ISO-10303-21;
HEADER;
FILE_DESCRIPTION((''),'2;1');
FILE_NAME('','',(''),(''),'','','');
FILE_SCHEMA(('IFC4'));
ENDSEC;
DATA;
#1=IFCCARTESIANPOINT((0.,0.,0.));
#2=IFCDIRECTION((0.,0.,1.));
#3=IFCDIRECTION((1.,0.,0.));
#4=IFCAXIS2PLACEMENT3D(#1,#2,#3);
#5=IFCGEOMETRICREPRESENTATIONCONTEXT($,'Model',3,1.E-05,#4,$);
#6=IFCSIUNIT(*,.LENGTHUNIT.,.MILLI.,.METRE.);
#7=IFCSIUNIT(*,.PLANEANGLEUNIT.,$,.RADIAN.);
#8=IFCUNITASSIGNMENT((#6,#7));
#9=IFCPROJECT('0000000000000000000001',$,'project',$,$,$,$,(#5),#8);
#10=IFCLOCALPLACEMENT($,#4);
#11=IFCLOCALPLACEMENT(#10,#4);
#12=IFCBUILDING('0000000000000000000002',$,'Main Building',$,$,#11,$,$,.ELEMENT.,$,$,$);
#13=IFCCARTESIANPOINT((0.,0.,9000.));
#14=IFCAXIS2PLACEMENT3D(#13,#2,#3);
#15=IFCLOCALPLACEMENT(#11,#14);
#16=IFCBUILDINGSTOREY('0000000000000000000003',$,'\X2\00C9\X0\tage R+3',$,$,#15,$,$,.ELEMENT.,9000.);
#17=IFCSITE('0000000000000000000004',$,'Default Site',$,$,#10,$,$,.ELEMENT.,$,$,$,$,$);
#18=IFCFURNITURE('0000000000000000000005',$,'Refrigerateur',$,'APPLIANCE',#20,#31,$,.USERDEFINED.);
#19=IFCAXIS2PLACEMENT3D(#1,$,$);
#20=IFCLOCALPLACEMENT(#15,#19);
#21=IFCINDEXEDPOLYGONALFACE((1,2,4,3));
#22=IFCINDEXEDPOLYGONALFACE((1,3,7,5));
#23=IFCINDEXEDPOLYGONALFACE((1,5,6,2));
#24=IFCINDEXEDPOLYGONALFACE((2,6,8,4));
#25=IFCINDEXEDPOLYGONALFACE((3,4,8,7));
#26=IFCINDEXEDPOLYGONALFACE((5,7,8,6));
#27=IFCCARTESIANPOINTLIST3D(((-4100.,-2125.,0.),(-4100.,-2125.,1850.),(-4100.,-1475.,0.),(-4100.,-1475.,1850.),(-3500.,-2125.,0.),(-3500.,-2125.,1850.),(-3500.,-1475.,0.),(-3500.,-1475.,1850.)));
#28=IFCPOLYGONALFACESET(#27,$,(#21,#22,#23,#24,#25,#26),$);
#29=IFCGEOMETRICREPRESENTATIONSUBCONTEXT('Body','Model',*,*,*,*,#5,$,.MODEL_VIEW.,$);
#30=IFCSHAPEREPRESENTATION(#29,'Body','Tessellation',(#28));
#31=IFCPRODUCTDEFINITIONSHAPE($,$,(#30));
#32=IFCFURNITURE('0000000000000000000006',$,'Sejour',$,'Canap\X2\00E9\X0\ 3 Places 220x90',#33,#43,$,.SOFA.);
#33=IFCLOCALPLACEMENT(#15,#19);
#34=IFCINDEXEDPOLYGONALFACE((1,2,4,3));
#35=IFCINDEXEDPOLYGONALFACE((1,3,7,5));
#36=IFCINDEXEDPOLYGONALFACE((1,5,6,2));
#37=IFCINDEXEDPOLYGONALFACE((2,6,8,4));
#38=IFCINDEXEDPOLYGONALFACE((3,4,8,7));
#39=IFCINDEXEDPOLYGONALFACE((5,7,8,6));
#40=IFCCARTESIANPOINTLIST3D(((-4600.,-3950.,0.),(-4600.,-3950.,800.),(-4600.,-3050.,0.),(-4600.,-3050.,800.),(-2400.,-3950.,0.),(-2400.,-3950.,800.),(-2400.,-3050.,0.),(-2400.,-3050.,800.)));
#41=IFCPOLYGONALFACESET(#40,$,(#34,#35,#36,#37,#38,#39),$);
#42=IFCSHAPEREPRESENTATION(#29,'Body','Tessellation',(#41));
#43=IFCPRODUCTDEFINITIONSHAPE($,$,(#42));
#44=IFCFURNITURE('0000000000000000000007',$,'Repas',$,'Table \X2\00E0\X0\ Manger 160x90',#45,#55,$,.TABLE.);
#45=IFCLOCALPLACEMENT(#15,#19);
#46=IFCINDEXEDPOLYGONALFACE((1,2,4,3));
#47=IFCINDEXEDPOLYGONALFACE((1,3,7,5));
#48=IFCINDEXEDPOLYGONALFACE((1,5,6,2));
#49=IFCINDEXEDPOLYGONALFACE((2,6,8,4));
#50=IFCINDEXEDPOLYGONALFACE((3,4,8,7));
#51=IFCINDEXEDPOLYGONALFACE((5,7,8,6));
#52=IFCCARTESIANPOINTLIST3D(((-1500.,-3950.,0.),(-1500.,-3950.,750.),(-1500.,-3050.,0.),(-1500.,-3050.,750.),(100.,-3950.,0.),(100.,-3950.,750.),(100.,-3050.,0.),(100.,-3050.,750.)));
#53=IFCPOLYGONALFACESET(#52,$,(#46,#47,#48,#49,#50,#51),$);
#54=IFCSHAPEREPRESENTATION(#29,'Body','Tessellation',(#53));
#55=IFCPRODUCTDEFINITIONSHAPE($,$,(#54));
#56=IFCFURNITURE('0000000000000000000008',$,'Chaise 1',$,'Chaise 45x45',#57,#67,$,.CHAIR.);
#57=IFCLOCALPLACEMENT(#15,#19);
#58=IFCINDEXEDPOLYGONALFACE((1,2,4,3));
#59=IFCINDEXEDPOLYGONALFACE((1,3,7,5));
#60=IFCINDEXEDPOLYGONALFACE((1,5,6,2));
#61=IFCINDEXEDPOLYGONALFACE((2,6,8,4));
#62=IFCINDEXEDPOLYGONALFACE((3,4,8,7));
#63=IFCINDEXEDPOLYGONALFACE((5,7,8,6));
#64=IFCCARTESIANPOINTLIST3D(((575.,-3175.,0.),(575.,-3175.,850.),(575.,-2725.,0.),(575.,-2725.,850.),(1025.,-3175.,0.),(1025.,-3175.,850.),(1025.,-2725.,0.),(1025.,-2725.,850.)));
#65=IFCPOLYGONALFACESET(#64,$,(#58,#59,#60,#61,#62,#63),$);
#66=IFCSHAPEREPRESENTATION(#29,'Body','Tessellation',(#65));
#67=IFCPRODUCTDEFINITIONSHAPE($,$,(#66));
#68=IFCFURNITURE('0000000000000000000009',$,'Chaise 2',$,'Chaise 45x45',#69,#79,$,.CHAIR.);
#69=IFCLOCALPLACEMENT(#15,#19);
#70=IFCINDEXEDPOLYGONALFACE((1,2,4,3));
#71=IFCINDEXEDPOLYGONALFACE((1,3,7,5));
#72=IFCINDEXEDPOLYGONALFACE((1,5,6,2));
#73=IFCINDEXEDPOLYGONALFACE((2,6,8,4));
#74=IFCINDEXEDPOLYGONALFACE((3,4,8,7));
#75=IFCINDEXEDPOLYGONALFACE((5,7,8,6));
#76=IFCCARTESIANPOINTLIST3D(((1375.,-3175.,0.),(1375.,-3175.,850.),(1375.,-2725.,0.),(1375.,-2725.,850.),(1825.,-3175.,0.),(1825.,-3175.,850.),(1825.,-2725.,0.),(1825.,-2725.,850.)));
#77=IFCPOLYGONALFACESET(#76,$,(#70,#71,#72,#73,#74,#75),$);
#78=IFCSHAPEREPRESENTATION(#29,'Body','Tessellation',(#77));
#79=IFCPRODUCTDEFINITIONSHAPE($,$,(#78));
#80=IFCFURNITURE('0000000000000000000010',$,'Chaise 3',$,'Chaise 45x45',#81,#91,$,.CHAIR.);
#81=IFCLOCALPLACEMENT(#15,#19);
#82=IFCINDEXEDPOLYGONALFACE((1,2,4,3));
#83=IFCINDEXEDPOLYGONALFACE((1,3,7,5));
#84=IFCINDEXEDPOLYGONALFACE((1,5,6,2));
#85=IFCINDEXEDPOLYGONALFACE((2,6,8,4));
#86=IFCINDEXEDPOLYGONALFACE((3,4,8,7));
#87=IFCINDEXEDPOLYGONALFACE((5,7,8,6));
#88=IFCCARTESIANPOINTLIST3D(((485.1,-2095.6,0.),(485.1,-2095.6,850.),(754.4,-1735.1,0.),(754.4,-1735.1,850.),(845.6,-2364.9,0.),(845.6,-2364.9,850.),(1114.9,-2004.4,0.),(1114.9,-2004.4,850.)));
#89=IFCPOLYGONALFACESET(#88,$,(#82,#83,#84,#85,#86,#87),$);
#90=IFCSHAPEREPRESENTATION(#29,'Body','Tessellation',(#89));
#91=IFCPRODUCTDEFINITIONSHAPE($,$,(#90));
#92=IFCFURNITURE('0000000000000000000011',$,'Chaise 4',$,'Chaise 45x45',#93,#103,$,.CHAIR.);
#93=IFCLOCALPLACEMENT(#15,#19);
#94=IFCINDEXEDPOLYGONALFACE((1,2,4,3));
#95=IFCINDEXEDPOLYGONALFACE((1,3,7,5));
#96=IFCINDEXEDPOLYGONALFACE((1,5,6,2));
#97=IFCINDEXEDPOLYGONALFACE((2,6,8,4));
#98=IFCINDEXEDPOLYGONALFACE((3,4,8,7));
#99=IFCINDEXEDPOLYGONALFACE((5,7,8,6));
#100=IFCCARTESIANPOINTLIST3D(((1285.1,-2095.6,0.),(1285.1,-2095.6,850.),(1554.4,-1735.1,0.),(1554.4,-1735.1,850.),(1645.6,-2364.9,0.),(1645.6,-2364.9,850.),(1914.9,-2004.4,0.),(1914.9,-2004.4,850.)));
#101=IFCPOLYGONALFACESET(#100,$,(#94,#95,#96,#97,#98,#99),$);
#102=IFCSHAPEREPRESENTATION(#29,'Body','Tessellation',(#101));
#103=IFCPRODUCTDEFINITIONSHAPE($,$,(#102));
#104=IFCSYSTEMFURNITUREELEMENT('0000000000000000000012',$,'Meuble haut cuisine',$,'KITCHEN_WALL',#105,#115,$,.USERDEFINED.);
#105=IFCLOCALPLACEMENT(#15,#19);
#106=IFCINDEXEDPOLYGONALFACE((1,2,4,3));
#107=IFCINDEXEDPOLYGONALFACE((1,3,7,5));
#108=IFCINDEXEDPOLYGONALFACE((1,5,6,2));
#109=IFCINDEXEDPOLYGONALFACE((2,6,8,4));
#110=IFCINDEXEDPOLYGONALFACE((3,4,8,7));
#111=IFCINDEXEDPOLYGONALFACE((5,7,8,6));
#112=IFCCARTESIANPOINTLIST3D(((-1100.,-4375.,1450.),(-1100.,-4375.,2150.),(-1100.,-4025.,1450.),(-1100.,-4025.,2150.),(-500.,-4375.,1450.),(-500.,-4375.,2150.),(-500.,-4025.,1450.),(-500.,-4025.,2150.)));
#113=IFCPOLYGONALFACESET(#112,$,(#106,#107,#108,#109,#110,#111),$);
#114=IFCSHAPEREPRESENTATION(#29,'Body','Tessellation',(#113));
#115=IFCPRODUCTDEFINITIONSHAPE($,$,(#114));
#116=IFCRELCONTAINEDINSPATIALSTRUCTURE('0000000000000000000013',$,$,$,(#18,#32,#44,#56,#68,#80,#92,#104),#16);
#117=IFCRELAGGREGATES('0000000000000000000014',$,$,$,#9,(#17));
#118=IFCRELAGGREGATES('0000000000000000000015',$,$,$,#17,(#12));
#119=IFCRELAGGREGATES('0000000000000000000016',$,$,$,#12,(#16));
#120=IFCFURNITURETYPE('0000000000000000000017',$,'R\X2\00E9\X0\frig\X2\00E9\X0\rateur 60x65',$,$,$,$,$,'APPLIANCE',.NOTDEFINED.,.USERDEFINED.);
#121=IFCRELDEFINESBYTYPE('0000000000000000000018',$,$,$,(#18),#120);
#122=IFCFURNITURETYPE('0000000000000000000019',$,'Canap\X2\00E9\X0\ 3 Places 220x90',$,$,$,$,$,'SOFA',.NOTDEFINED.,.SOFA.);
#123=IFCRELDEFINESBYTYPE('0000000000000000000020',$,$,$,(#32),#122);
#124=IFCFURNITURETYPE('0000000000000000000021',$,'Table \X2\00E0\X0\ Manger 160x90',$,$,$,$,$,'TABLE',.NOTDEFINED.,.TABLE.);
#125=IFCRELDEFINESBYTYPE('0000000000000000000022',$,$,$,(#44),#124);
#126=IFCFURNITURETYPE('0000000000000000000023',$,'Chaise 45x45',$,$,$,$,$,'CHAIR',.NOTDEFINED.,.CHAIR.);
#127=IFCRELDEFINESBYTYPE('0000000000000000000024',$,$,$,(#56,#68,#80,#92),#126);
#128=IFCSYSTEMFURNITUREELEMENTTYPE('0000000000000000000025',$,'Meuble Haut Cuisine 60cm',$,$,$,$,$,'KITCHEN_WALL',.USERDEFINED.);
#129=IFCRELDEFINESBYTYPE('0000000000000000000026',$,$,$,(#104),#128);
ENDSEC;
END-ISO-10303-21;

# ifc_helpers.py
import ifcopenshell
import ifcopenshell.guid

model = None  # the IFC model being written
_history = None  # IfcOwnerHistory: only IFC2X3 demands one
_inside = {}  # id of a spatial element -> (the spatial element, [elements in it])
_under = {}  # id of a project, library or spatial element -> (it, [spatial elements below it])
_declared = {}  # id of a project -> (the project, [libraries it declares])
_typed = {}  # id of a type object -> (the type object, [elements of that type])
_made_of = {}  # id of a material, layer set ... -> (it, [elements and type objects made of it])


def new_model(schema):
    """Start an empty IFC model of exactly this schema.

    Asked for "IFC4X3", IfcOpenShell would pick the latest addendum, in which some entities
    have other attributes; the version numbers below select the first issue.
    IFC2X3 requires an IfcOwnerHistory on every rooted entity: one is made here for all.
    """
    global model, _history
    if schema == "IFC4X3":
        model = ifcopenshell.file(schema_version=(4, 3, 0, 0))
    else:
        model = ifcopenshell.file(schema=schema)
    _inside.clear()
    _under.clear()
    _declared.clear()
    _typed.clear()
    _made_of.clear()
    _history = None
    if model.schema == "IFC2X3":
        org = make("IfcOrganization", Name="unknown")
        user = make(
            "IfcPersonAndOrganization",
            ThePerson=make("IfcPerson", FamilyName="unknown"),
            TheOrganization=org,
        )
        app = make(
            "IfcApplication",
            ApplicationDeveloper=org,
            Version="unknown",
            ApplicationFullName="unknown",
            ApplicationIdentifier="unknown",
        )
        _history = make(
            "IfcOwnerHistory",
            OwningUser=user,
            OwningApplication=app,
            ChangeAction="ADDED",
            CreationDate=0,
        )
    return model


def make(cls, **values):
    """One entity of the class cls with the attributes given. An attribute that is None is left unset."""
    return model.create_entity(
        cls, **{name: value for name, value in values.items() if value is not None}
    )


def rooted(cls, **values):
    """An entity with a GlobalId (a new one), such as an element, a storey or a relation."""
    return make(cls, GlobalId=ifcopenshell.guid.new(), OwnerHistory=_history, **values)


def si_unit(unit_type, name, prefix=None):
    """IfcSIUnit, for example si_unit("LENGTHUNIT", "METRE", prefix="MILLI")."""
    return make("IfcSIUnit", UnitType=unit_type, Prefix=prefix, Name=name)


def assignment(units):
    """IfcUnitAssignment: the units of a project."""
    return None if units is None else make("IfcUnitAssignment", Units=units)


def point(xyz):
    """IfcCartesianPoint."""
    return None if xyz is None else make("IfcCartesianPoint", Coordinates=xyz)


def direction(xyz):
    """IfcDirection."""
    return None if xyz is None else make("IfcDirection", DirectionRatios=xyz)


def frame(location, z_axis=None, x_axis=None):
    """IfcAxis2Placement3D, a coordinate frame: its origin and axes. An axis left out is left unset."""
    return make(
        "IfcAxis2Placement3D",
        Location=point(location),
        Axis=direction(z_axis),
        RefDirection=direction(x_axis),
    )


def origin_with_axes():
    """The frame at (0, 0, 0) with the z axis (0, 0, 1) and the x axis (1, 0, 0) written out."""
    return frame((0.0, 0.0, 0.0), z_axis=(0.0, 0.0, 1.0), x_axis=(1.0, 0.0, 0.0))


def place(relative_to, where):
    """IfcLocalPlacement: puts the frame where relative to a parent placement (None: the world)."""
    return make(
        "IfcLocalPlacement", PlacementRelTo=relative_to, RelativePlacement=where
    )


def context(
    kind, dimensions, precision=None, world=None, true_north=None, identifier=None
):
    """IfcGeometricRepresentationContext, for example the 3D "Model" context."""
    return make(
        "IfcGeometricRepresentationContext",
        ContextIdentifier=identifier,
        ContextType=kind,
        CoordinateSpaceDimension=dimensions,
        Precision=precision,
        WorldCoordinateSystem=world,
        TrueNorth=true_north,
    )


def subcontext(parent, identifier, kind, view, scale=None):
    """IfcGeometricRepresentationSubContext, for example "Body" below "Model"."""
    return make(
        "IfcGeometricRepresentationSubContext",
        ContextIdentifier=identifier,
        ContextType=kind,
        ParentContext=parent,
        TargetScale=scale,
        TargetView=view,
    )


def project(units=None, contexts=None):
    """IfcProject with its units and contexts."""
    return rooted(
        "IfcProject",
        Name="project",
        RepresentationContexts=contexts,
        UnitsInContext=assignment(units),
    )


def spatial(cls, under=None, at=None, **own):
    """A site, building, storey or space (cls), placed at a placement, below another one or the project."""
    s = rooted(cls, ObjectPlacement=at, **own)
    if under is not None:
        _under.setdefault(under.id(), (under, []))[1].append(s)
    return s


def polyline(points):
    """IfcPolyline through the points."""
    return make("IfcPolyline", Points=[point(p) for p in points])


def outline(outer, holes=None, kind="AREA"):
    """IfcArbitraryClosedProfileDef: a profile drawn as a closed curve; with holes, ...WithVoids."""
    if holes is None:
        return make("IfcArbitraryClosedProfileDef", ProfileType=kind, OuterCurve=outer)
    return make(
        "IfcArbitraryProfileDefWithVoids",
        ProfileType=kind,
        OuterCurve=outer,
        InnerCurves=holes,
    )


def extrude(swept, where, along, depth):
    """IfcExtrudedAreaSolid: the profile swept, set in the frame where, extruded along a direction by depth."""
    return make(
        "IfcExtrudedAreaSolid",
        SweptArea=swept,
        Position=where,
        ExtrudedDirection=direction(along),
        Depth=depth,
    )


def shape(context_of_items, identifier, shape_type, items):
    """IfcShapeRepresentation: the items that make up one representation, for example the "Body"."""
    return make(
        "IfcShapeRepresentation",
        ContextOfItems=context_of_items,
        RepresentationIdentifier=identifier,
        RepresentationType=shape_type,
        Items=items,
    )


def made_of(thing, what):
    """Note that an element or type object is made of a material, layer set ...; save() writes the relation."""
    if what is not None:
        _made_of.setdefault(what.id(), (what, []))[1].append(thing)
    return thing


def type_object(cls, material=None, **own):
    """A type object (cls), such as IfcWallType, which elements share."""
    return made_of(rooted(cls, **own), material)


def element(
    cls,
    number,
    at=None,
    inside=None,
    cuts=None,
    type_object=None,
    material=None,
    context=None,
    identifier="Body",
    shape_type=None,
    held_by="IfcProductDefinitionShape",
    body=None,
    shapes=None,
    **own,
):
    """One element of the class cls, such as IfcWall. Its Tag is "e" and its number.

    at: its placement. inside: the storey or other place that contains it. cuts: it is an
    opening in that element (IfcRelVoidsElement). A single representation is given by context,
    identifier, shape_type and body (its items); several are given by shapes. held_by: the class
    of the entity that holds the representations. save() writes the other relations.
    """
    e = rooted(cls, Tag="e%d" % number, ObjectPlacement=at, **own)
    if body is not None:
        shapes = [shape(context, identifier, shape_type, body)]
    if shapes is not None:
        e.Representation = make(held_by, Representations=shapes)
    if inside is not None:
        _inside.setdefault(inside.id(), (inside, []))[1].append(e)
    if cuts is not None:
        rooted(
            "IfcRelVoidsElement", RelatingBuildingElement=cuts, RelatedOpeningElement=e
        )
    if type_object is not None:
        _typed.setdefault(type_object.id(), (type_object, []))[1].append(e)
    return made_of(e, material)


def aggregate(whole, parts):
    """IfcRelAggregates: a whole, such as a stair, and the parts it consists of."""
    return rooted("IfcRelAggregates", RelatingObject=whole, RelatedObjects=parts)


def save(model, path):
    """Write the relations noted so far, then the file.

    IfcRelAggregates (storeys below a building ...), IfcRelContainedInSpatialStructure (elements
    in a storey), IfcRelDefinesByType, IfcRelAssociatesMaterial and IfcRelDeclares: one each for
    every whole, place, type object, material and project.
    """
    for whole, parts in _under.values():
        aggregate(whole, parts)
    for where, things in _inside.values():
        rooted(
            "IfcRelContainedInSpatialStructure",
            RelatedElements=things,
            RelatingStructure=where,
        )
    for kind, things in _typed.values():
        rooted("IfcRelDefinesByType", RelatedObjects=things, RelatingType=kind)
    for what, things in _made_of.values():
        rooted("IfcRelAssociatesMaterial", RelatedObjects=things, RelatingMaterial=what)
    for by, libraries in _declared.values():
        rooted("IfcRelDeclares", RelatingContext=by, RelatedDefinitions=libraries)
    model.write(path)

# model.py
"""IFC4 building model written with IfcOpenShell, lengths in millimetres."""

from ifc_helpers import new_model, si_unit, frame, origin_with_axes, place, context, subcontext, project, spatial, polyline, outline, extrude, type_object, element, save


model = new_model("IFC4")

# Units and contexts
model_context = context("Model", 3, precision=1e-05, world=origin_with_axes())
body_context = subcontext(model_context, "Body", "Model", "MODEL_VIEW")
ifc_project = project(units=[si_unit("LENGTHUNIT", "METRE", prefix="MILLI"), si_unit("PLANEANGLEUNIT", "RADIAN")], contexts=[model_context])

# Site, building, storey
site_placement = place(None, origin_with_axes())
site = spatial("IfcSite", under=ifc_project, at=site_placement, Name="Default Site", CompositionType="ELEMENT")
building_placement = place(site_placement, origin_with_axes())
building = spatial("IfcBuilding", under=site, at=building_placement, Name="Main Building", CompositionType="ELEMENT")
storey_placement = place(building_placement, frame((0.0, 0.0, 9000.0), z_axis=(0.0, 0.0, 1.0), x_axis=(1.0, 0.0, 0.0)))
storey = spatial("IfcBuildingStorey", under=building, at=storey_placement, Name="Étage R+3", CompositionType="ELEMENT", Elevation=9000.0)

# Furniture
furniture_type_1 = type_object("IfcFurnitureType", Name="Réfrigérateur 60x65", ElementType="APPLIANCE", AssemblyPlace="NOTDEFINED", PredefinedType="USERDEFINED")
furniture_1_placement = place(storey_placement, frame((-3800.0, -1800.0, 0.0), z_axis=(0.0, 0.0, 1.0), x_axis=(1.0, 0.0, 0.0)))
element("IfcFurniture", 1, at=furniture_1_placement, inside=storey, type_object=furniture_type_1, Name="Refrigerateur", ObjectType="APPLIANCE", PredefinedType="USERDEFINED", context=body_context, shape_type="SweptSolid", body=[
    extrude(outline(polyline([(-300.0, -325.0), (300.0, -325.0), (300.0, 325.0), (-300.0, 325.0), (-300.0, -325.0)])), origin_with_axes(), (0.0, 0.0, 1.0), 1850.0),
])
furniture_type_2 = type_object("IfcFurnitureType", Name="Canapé 3 Places 220x90", ElementType="SOFA", AssemblyPlace="NOTDEFINED", PredefinedType="SOFA")
furniture_2_placement = place(storey_placement, frame((-3500.0, -3500.0, 0.0), z_axis=(0.0, 0.0, 1.0), x_axis=(1.0, 0.0, 0.0)))
element("IfcFurniture", 2, at=furniture_2_placement, inside=storey, type_object=furniture_type_2, Name="Sejour", ObjectType="Canapé 3 Places 220x90", PredefinedType="SOFA", context=body_context, shape_type="SweptSolid", body=[
    extrude(outline(polyline([(-1100.0, -450.0), (1100.0, -450.0), (1100.0, 450.0), (-1100.0, 450.0), (-1100.0, -450.0)])), origin_with_axes(), (0.0, 0.0, 1.0), 800.0),
])
furniture_type_3 = type_object("IfcFurnitureType", Name="Table à Manger 160x90", ElementType="TABLE", AssemblyPlace="NOTDEFINED", PredefinedType="TABLE")
furniture_3_placement = place(storey_placement, frame((-700.0, -3500.0, 0.0), z_axis=(0.0, 0.0, 1.0), x_axis=(1.0, 0.0, 0.0)))
element("IfcFurniture", 3, at=furniture_3_placement, inside=storey, type_object=furniture_type_3, Name="Repas", ObjectType="Table à Manger 160x90", PredefinedType="TABLE", context=body_context, shape_type="SweptSolid", body=[
    extrude(outline(polyline([(-800.0, -450.0), (800.0, -450.0), (800.0, 450.0), (-800.0, 450.0), (-800.0, -450.0)])), origin_with_axes(), (0.0, 0.0, 1.0), 750.0),
])
furniture_type_4 = type_object("IfcFurnitureType", Name="Chaise 45x45", ElementType="CHAIR", AssemblyPlace="NOTDEFINED", PredefinedType="CHAIR")
for number, where, z_axis, x_axis, name in (
    (4, (800.0, -2950.0, 0.0), (0.0, 0.0, 1.0), (1.0, 0.0, 0.0), "Chaise 1"),
    (5, (1600.0, -2950.0, 0.0), (0.0, 0.0, 1.0), (1.0, 0.0, 0.0), "Chaise 2"),
    (6, (800.0, -2050.0, 0.0), (0.0, 0.0, 1.0), (-0.59846, -0.801153, 0.0), "Chaise 3"),
    (7, (1600.0, -2050.0, 0.0), (0.0, 0.0, 1.0), (-0.59846, -0.801153, 0.0), "Chaise 4"),
):
    element("IfcFurniture", number, at=place(storey_placement, frame(where, z_axis=z_axis, x_axis=x_axis)), inside=storey, type_object=furniture_type_4, Name=name, ObjectType="Chaise 45x45", PredefinedType="CHAIR", context=body_context, shape_type="SweptSolid", body=[
        extrude(outline(polyline([(-225.0, -225.0), (225.0, -225.0), (225.0, 225.0), (-225.0, 225.0), (-225.0, -225.0)])), origin_with_axes(), (0.0, 0.0, 1.0), 850.0),
    ])

# System furniture element
system_furniture_element_type = type_object("IfcSystemFurnitureElementType", Name="Meuble Haut Cuisine 60cm", ElementType="KITCHEN_WALL", PredefinedType="USERDEFINED")
system_furniture_element_placement = place(storey_placement, frame((-800.0, -4200.0, 1450.0), z_axis=(0.0, 0.0, 1.0), x_axis=(1.0, 0.0, 0.0)))
element("IfcSystemFurnitureElement", 8, at=system_furniture_element_placement, inside=storey, type_object=system_furniture_element_type, Name="Meuble haut cuisine", ObjectType="KITCHEN_WALL", PredefinedType="USERDEFINED", context=body_context, shape_type="SweptSolid", body=[
    extrude(outline(polyline([(-300.0, -175.0), (300.0, -175.0), (300.0, 175.0), (-300.0, 175.0), (-300.0, -175.0)])), origin_with_axes(), (0.0, 0.0, 1.0), 700.0),
])

save(model, "model.ifc")
